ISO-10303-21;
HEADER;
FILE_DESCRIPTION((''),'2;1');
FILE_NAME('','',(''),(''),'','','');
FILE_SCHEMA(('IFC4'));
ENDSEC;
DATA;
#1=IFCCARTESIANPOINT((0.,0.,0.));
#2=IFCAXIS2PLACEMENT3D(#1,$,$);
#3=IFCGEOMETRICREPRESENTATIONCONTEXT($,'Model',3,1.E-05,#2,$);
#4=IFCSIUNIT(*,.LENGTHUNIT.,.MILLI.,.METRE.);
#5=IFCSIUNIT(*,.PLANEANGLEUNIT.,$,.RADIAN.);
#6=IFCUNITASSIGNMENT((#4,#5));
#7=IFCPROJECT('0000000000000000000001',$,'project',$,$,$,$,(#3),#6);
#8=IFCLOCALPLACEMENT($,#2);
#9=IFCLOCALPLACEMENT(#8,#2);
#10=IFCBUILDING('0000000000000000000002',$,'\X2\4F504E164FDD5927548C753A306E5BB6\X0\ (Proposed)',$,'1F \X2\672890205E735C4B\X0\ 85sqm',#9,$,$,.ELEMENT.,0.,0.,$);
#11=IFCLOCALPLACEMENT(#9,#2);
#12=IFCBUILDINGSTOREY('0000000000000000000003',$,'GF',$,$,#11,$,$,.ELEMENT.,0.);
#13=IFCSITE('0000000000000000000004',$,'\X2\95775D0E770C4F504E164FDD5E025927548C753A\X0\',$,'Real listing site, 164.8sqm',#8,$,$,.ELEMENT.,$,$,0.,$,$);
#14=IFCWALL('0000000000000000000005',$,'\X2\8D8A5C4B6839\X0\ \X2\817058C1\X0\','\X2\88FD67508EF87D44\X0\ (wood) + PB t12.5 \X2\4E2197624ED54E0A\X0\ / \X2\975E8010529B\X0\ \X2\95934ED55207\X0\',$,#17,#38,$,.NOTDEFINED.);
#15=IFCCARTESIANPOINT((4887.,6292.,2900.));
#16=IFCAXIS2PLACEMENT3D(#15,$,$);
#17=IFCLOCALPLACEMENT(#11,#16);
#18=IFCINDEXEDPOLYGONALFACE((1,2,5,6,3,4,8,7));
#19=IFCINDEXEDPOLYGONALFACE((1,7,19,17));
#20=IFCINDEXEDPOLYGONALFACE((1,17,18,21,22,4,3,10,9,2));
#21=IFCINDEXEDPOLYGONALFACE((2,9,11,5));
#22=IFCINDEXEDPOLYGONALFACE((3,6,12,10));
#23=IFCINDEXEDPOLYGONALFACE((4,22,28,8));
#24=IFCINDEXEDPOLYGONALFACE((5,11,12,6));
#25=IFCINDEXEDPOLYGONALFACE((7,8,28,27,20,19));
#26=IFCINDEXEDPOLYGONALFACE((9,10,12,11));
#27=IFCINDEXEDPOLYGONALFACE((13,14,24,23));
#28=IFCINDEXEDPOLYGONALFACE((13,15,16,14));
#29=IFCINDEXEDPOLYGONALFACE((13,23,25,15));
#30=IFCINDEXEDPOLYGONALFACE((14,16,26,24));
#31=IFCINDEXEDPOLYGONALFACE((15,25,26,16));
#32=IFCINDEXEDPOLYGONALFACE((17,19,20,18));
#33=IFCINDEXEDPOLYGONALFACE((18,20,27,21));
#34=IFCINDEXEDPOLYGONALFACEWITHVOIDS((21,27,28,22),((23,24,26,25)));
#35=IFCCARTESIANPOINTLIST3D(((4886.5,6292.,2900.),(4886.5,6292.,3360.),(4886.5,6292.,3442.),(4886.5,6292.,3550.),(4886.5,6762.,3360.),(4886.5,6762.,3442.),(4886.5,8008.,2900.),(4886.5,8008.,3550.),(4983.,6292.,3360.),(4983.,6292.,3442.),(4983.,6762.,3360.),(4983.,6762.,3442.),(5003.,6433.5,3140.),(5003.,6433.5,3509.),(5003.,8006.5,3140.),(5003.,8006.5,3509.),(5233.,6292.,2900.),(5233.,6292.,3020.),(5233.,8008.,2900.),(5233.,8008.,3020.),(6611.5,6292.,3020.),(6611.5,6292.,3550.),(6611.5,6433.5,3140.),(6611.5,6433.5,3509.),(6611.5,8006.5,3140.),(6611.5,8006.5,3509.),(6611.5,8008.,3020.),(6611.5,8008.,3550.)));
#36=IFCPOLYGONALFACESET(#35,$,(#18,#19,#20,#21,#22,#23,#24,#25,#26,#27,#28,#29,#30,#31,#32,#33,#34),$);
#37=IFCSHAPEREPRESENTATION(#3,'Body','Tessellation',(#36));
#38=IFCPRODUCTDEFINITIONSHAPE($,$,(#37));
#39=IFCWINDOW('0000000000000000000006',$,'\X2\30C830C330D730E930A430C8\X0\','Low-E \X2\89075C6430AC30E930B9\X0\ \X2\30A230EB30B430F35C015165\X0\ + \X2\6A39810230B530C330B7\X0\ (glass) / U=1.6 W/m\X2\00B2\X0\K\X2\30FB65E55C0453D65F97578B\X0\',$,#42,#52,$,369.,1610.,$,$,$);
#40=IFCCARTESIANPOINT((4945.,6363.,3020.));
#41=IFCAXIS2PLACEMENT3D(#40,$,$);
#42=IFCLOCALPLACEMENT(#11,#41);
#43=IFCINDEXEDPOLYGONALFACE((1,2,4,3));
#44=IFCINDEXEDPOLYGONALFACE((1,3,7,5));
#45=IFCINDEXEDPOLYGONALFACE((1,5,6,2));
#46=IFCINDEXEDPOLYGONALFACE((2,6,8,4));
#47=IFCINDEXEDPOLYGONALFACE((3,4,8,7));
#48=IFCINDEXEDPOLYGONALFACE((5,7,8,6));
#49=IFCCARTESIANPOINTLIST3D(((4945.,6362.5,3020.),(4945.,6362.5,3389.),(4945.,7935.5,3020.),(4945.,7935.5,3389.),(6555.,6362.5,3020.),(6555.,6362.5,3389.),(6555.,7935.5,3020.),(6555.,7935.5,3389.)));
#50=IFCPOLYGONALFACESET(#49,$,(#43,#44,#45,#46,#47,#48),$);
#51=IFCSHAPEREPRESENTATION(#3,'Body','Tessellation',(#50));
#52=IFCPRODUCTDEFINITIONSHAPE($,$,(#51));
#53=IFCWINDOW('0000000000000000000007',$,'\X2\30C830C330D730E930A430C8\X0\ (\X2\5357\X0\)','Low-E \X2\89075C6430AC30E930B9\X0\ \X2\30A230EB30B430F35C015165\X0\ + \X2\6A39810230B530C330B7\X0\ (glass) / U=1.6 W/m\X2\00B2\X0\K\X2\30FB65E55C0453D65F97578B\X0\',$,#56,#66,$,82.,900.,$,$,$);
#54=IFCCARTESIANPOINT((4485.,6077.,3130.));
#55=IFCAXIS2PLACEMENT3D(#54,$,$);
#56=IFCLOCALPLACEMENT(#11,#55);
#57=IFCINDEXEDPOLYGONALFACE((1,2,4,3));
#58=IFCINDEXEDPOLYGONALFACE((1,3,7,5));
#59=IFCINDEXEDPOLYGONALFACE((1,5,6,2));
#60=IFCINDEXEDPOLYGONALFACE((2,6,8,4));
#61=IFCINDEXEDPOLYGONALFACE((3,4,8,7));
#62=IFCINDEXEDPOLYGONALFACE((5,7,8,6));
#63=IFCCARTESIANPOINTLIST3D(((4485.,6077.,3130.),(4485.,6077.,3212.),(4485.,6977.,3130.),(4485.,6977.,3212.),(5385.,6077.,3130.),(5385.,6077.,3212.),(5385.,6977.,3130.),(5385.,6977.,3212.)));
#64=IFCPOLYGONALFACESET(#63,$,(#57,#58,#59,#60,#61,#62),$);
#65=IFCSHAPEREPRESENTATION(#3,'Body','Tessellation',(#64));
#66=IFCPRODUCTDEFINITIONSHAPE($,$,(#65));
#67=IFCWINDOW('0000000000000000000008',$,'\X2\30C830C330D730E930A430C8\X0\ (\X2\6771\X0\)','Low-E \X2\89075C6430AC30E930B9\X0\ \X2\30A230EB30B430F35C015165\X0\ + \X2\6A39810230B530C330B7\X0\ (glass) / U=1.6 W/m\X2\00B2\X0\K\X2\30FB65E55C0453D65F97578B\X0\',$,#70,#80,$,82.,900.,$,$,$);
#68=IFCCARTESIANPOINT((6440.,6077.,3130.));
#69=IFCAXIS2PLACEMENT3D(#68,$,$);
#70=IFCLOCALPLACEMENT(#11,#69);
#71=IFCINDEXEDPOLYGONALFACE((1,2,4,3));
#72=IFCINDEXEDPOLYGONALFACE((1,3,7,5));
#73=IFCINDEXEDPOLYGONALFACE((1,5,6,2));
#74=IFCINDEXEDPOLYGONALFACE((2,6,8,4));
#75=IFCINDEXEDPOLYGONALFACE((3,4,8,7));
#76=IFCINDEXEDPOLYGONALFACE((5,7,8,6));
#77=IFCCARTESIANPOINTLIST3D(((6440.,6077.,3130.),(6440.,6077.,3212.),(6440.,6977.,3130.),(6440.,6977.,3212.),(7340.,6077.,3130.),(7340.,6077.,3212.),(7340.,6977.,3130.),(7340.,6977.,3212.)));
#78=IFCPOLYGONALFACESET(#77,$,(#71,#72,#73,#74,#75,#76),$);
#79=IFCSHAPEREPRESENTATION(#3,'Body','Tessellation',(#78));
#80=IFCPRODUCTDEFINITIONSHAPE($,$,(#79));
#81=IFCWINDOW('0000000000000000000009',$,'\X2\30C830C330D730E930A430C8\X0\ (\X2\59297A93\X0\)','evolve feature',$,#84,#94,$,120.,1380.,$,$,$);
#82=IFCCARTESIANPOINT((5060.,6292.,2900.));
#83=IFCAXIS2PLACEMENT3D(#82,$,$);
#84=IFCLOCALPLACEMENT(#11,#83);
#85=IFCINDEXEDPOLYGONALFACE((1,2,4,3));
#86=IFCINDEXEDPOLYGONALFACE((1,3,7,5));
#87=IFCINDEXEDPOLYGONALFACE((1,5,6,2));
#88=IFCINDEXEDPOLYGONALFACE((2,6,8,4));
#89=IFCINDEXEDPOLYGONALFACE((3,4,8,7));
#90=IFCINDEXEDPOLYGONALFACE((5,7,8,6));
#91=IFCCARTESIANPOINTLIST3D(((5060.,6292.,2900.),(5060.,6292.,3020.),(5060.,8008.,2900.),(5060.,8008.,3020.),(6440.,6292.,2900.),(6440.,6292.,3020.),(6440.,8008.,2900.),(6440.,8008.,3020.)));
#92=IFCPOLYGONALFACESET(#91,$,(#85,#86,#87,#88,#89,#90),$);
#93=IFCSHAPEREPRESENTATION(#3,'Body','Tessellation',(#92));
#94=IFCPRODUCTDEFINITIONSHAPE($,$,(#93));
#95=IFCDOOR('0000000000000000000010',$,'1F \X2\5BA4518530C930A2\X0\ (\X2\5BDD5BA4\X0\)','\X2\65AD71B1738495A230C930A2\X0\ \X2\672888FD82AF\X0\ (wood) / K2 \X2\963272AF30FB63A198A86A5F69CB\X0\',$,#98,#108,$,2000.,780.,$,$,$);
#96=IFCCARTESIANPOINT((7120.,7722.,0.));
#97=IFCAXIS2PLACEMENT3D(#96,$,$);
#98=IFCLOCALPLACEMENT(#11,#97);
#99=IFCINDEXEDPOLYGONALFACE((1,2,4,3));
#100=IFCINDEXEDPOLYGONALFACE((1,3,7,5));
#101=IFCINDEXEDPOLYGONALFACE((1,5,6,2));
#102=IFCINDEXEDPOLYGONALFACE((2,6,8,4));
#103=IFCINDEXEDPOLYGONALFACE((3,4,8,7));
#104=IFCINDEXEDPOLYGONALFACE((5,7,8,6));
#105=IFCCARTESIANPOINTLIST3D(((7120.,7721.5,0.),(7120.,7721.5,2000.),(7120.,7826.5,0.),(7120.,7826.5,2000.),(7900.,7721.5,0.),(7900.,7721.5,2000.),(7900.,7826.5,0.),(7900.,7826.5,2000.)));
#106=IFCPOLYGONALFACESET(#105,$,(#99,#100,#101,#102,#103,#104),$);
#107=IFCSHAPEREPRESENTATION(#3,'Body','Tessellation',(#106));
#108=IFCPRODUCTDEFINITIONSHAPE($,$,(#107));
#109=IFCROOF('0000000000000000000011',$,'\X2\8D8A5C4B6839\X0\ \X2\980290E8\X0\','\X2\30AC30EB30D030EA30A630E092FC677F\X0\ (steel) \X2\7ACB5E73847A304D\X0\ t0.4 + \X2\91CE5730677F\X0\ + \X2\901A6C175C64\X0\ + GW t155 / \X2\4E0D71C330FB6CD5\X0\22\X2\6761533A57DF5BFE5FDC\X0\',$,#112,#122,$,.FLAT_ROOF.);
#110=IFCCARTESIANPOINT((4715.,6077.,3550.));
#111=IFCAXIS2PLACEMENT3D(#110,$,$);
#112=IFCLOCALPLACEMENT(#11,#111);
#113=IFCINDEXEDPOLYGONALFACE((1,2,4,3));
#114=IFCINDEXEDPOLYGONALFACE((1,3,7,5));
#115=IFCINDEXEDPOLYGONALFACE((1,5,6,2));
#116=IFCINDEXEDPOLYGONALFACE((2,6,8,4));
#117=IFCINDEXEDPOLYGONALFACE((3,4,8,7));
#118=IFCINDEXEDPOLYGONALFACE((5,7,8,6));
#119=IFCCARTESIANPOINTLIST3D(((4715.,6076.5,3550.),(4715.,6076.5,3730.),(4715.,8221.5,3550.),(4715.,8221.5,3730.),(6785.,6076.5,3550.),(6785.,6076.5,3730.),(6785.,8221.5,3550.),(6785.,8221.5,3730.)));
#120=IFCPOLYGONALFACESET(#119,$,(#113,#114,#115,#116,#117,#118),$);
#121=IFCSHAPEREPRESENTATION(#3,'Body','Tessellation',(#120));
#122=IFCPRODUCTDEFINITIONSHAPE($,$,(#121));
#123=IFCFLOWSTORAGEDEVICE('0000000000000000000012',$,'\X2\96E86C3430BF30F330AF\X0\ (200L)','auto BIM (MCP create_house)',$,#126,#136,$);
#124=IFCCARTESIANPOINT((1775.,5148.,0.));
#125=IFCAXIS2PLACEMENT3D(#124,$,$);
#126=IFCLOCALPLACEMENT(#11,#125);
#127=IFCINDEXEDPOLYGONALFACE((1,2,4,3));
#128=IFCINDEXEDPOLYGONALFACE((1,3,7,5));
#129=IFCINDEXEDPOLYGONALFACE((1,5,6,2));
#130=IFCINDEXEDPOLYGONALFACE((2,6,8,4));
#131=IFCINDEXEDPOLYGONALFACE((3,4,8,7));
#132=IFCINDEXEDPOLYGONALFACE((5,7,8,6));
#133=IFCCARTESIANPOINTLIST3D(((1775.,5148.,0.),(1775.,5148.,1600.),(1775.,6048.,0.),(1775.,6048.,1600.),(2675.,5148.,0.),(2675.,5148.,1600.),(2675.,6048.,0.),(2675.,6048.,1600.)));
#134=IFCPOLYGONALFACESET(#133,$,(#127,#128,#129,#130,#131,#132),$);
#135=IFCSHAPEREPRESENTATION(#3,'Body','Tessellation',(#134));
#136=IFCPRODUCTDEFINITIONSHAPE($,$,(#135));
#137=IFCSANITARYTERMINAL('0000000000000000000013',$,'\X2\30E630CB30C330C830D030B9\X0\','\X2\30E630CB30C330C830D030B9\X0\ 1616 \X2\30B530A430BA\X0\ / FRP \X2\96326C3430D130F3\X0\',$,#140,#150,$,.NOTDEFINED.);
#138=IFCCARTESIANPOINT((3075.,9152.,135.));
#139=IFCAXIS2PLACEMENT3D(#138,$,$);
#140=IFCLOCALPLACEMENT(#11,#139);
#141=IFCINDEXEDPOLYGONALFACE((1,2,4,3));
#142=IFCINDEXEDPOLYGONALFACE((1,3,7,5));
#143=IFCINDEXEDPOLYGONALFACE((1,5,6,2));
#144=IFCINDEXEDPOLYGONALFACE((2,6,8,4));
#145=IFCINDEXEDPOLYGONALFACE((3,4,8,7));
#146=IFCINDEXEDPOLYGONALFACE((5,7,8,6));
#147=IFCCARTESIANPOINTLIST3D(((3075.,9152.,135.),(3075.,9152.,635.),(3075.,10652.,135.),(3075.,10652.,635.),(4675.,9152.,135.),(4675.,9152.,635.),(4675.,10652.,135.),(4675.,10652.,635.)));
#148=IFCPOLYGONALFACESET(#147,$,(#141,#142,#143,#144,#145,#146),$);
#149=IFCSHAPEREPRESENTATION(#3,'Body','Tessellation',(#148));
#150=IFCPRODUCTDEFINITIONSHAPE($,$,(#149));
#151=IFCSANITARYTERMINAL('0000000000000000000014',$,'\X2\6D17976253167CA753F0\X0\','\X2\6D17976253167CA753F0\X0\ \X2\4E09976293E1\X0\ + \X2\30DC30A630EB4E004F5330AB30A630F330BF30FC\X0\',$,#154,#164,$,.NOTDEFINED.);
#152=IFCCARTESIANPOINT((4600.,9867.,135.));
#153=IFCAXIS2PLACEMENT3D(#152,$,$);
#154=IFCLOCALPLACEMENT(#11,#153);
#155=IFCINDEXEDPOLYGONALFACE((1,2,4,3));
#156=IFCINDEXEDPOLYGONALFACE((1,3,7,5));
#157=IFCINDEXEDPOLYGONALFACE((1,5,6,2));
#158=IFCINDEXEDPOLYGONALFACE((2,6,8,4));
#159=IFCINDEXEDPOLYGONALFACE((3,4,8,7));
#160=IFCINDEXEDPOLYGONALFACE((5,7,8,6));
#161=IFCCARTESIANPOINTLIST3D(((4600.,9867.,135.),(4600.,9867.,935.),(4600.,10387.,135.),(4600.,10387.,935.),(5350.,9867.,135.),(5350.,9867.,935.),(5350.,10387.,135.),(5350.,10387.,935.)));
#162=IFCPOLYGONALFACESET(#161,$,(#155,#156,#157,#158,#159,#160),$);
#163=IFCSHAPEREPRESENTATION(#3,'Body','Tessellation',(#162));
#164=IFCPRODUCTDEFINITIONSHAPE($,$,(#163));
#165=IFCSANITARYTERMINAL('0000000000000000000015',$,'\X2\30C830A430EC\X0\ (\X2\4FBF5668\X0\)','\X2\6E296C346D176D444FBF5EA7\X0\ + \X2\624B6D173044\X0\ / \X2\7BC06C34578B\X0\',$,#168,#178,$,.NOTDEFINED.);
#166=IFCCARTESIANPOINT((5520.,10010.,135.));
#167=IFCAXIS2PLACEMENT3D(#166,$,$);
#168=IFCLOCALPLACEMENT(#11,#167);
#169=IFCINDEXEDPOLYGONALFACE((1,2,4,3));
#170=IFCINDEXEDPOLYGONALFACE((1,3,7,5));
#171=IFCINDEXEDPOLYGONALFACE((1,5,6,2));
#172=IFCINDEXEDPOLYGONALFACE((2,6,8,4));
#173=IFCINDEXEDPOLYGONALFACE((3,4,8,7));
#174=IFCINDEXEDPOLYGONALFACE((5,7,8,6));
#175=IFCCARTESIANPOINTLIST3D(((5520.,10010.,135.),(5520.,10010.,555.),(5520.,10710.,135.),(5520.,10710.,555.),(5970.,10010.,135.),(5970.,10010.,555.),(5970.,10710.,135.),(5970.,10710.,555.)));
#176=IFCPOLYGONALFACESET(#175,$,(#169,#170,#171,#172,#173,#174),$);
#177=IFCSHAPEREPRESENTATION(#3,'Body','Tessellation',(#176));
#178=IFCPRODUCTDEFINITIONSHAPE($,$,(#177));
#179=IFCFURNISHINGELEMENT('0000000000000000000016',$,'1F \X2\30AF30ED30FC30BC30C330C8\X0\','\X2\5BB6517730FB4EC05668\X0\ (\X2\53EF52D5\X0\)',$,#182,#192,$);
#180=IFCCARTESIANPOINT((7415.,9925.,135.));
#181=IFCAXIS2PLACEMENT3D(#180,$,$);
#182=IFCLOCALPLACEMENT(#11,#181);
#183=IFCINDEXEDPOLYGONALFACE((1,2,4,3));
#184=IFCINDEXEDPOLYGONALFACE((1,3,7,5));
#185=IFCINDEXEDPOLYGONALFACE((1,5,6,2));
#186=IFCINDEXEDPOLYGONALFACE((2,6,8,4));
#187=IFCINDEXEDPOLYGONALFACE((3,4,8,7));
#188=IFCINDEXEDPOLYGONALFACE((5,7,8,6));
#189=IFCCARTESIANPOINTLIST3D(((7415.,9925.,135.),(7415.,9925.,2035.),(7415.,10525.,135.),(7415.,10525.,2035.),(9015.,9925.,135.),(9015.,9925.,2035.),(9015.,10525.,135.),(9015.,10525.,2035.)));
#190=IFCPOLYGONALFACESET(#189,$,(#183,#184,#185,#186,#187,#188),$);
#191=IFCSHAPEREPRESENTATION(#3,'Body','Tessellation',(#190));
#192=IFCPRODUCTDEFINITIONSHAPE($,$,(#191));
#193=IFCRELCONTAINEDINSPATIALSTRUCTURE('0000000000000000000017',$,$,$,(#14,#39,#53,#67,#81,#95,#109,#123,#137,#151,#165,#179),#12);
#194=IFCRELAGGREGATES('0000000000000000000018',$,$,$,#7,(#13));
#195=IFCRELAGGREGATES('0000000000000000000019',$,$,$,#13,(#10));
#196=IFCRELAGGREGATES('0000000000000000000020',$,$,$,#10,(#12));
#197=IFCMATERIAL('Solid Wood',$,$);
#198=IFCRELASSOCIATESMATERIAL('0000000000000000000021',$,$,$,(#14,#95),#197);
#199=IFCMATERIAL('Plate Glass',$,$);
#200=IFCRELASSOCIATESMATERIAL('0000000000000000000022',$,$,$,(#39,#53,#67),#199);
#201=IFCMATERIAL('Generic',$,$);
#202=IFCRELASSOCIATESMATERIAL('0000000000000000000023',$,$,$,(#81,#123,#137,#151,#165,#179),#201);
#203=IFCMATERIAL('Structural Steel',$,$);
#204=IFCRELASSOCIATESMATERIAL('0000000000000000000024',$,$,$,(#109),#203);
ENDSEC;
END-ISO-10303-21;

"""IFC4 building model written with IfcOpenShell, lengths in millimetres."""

from ifc_helpers import new_model, si_unit, frame, frame_2d, origin, place, context, project, spatial, rectangle, extrude, material, element, fill, save


model = new_model("IFC4")

# Units and contexts
model_context = context("Model", 3, precision=1e-05, world=origin())
ifc_project = project(units=[si_unit("LENGTHUNIT", "METRE", prefix="MILLI"), si_unit("PLANEANGLEUNIT", "RADIAN")], contexts=[model_context])

# Site, building, storey
site_placement = place(None, origin())
site = spatial("IfcSite", under=ifc_project, at=site_placement, Name="長崎県佐世保市大和町", ObjectType="Real listing site, 164.8sqm", CompositionType="ELEMENT", RefElevation=0.0)
building_placement = place(site_placement, origin())
building = spatial("IfcBuilding", under=site, at=building_placement, Name="佐世保大和町の家 (Proposed)", ObjectType="1F 木造平屋 85sqm", CompositionType="ELEMENT", ElevationOfRefHeight=0.0, ElevationOfTerrain=0.0)
storey_placement = place(building_placement, origin())
storey = spatial("IfcBuildingStorey", under=building, at=storey_placement, Name="GF", CompositionType="ELEMENT", Elevation=0.0)

# Shared definitions
ifc_material_1 = material(Name="Solid Wood")

# Shared definitions
ifc_material_2 = material(Name="Plate Glass")

# Wall, openings, windows
wall_1_placement = place(storey_placement, frame((4887.0, 6292.0, 2900.0)))
wall_1 = element("IfcWall", 1, at=wall_1_placement, inside=storey, material=ifc_material_1, Name="越屋根 腰壁", Description="製材軸組 (wood) + PB t12.5 両面仕上 / 非耐力 間仕切", PredefinedType="NOTDEFINED", context=model_context, shape_type="SweptSolid", body=[
    extrude(rectangle(XDim=1725.0, YDim=1716.0, at=frame_2d((862.0, 858.0))), frame((4887.0, 6292.0, 2900.0)), (0.0, 0.0, 1.0), 650.0),
])
opening_1_placement = place(storey_placement, frame((4945.0, 6363.0, 3020.0)))
opening_1 = element("IfcOpeningElement", 2, at=opening_1_placement, cuts=wall_1, PredefinedType="NOTDEFINED", context=model_context, shape_type="SweptSolid", body=[
    extrude(rectangle(XDim=1610.0, YDim=1573.0, at=frame_2d((805.0, 786.0))), frame((4945.0, 6363.0, 3020.0)), (0.0, 0.0, 1.0), 369.0),
])
opening_2_placement = place(storey_placement, frame((4485.0, 6077.0, 3130.0)))
opening_2 = element("IfcOpeningElement", 3, at=opening_2_placement, cuts=wall_1, PredefinedType="NOTDEFINED", context=model_context, shape_type="SweptSolid", body=[
    extrude(rectangle(XDim=900.0, YDim=900.0, at=frame_2d((450.0, 450.0))), frame((4485.0, 6077.0, 3130.0)), (0.0, 0.0, 1.0), 82.0),
])
opening_3_placement = place(storey_placement, frame((6440.0, 6077.0, 3130.0)))
opening_3 = element("IfcOpeningElement", 4, at=opening_3_placement, cuts=wall_1, PredefinedType="NOTDEFINED", context=model_context, shape_type="SweptSolid", body=[
    extrude(rectangle(XDim=900.0, YDim=900.0, at=frame_2d((450.0, 450.0))), frame((6440.0, 6077.0, 3130.0)), (0.0, 0.0, 1.0), 82.0),
])
opening_4_placement = place(storey_placement, frame((5060.0, 6292.0, 2900.0)))
opening_4 = element("IfcOpeningElement", 5, at=opening_4_placement, cuts=wall_1, PredefinedType="NOTDEFINED", context=model_context, shape_type="SweptSolid", body=[
    extrude(rectangle(XDim=1380.0, YDim=1716.0, at=frame_2d((690.0, 858.0))), frame((5060.0, 6292.0, 2900.0)), (0.0, 0.0, 1.0), 120.0),
])
window_1_placement = place(storey_placement, frame((4945.0, 6363.0, 3020.0)))
window_1 = element("IfcWindow", 6, at=window_1_placement, inside=storey, material=ifc_material_2, Name="トップライト", Description="Low-E 複層ガラス アルゴン封入 + 樹脂サッシ (glass) / U=1.6 W/m²K・日射取得型", OverallHeight=369.0, OverallWidth=1610.0, context=model_context, shape_type="SweptSolid", body=[
    extrude(rectangle(XDim=1610.0, YDim=1573.0, at=frame_2d((805.0, 786.0))), frame((4945.0, 6363.0, 3020.0)), (0.0, 0.0, 1.0), 369.0),
])
fill(opening_1, window_1)
window_2_placement = place(storey_placement, frame((4485.0, 6077.0, 3130.0)))
window_2 = element("IfcWindow", 7, at=window_2_placement, inside=storey, material=ifc_material_2, Name="トップライト (南)", Description="Low-E 複層ガラス アルゴン封入 + 樹脂サッシ (glass) / U=1.6 W/m²K・日射取得型", OverallHeight=82.0, OverallWidth=900.0, context=model_context, shape_type="SweptSolid", body=[
    extrude(rectangle(XDim=900.0, YDim=900.0, at=frame_2d((450.0, 450.0))), frame((4485.0, 6077.0, 3130.0)), (0.0, 0.0, 1.0), 82.0),
])
fill(opening_2, window_2)
window_3_placement = place(storey_placement, frame((6440.0, 6077.0, 3130.0)))
window_3 = element("IfcWindow", 8, at=window_3_placement, inside=storey, material=ifc_material_2, Name="トップライト (東)", Description="Low-E 複層ガラス アルゴン封入 + 樹脂サッシ (glass) / U=1.6 W/m²K・日射取得型", OverallHeight=82.0, OverallWidth=900.0, context=model_context, shape_type="SweptSolid", body=[
    extrude(rectangle(XDim=900.0, YDim=900.0, at=frame_2d((450.0, 450.0))), frame((6440.0, 6077.0, 3130.0)), (0.0, 0.0, 1.0), 82.0),
])
fill(opening_3, window_3)
ifc_material_3 = material(Name="Generic")
window_4_placement = place(storey_placement, frame((5060.0, 6292.0, 2900.0)))
window_4 = element("IfcWindow", 9, at=window_4_placement, inside=storey, material=ifc_material_3, Name="トップライト (天窓)", Description="evolve feature", OverallHeight=120.0, OverallWidth=1380.0, context=model_context, shape_type="SweptSolid", body=[
    extrude(rectangle(XDim=1380.0, YDim=1716.0, at=frame_2d((690.0, 858.0))), frame((5060.0, 6292.0, 2900.0)), (0.0, 0.0, 1.0), 120.0),
])
fill(opening_4, window_4)

# Door
door_1_placement = place(storey_placement, frame((7120.0, 7722.0, 0.0)))
element("IfcDoor", 10, at=door_1_placement, inside=storey, material=ifc_material_1, Name="1F 室内ドア (寝室)", Description="断熱玄関ドア 木製芯 (wood) / K2 防犯・採風機構", OverallHeight=2000.0, OverallWidth=780.0, context=model_context, shape_type="SweptSolid", body=[
    extrude(rectangle(XDim=780.0, YDim=105.0, at=frame_2d((390.0, 52.0))), frame((7120.0, 7722.0, 0.0)), (0.0, 0.0, 1.0), 2000.0),
])

# Roof
ifc_material_4 = material(Name="Structural Steel")
roof_placement = place(storey_placement, frame((4715.0, 6077.0, 3550.0)))
element("IfcRoof", 11, at=roof_placement, inside=storey, material=ifc_material_4, Name="越屋根 頂部", Description="ガルバリウム鋼板 (steel) 立平葺き t0.4 + 野地板 + 通気層 + GW t155 / 不燃・法22条区域対応", PredefinedType="FLAT_ROOF", context=model_context, shape_type="SweptSolid", body=[
    extrude(rectangle(XDim=2070.0, YDim=2145.0, at=frame_2d((1035.0, 1072.0))), frame((4715.0, 6077.0, 3550.0)), (0.0, 0.0, 1.0), 180.0),
])

# Flow storage device
flow_storage_device_placement = place(storey_placement, frame((1775.0, 5148.0, 0.0)))
element("IfcFlowStorageDevice", 12, at=flow_storage_device_placement, inside=storey, material=ifc_material_3, Name="雨水タンク (200L)", Description="auto BIM (MCP create_house)", context=model_context, shape_type="SweptSolid", body=[
    extrude(rectangle(XDim=900.0, YDim=900.0, at=frame_2d((450.0, 450.0))), frame((1775.0, 5148.0, 0.0)), (0.0, 0.0, 1.0), 1600.0),
])

# Sanitary terminals
sanitary_terminal_1_placement = place(storey_placement, frame((3075.0, 9152.0, 135.0)))
element("IfcSanitaryTerminal", 13, at=sanitary_terminal_1_placement, inside=storey, material=ifc_material_3, Name="ユニットバス", Description="ユニットバス 1616 サイズ / FRP 防水パン", PredefinedType="NOTDEFINED", context=model_context, shape_type="SweptSolid", body=[
    extrude(rectangle(XDim=1600.0, YDim=1500.0, at=frame_2d((800.0, 750.0))), frame((3075.0, 9152.0, 135.0)), (0.0, 0.0, 1.0), 500.0),
])
sanitary_terminal_2_placement = place(storey_placement, frame((4600.0, 9867.0, 135.0)))
element("IfcSanitaryTerminal", 14, at=sanitary_terminal_2_placement, inside=storey, material=ifc_material_3, Name="洗面化粧台", Description="洗面化粧台 三面鏡 + ボウル一体カウンター", PredefinedType="NOTDEFINED", context=model_context, shape_type="SweptSolid", body=[
    extrude(rectangle(XDim=750.0, YDim=520.0, at=frame_2d((375.0, 260.0))), frame((4600.0, 9867.0, 135.0)), (0.0, 0.0, 1.0), 800.0),
])
sanitary_terminal_3_placement = place(storey_placement, frame((5520.0, 10010.0, 135.0)))
element("IfcSanitaryTerminal", 15, at=sanitary_terminal_3_placement, inside=storey, material=ifc_material_3, Name="トイレ (便器)", Description="温水洗浄便座 + 手洗い / 節水型", PredefinedType="NOTDEFINED", context=model_context, shape_type="SweptSolid", body=[
    extrude(rectangle(XDim=450.0, YDim=700.0, at=frame_2d((225.0, 350.0))), frame((5520.0, 10010.0, 135.0)), (0.0, 0.0, 1.0), 420.0),
])

# Furnishing element
furnishing_1_placement = place(storey_placement, frame((7415.0, 9925.0, 135.0)))
element("IfcFurnishingElement", 16, at=furnishing_1_placement, inside=storey, material=ifc_material_3, Name="1F クローゼット", Description="家具・什器 (可動)", context=model_context, shape_type="SweptSolid", body=[
    extrude(rectangle(XDim=1600.0, YDim=600.0, at=frame_2d((800.0, 300.0))), frame((7415.0, 9925.0, 135.0)), (0.0, 0.0, 1.0), 1900.0),
])

save(model, "model.ifc")
